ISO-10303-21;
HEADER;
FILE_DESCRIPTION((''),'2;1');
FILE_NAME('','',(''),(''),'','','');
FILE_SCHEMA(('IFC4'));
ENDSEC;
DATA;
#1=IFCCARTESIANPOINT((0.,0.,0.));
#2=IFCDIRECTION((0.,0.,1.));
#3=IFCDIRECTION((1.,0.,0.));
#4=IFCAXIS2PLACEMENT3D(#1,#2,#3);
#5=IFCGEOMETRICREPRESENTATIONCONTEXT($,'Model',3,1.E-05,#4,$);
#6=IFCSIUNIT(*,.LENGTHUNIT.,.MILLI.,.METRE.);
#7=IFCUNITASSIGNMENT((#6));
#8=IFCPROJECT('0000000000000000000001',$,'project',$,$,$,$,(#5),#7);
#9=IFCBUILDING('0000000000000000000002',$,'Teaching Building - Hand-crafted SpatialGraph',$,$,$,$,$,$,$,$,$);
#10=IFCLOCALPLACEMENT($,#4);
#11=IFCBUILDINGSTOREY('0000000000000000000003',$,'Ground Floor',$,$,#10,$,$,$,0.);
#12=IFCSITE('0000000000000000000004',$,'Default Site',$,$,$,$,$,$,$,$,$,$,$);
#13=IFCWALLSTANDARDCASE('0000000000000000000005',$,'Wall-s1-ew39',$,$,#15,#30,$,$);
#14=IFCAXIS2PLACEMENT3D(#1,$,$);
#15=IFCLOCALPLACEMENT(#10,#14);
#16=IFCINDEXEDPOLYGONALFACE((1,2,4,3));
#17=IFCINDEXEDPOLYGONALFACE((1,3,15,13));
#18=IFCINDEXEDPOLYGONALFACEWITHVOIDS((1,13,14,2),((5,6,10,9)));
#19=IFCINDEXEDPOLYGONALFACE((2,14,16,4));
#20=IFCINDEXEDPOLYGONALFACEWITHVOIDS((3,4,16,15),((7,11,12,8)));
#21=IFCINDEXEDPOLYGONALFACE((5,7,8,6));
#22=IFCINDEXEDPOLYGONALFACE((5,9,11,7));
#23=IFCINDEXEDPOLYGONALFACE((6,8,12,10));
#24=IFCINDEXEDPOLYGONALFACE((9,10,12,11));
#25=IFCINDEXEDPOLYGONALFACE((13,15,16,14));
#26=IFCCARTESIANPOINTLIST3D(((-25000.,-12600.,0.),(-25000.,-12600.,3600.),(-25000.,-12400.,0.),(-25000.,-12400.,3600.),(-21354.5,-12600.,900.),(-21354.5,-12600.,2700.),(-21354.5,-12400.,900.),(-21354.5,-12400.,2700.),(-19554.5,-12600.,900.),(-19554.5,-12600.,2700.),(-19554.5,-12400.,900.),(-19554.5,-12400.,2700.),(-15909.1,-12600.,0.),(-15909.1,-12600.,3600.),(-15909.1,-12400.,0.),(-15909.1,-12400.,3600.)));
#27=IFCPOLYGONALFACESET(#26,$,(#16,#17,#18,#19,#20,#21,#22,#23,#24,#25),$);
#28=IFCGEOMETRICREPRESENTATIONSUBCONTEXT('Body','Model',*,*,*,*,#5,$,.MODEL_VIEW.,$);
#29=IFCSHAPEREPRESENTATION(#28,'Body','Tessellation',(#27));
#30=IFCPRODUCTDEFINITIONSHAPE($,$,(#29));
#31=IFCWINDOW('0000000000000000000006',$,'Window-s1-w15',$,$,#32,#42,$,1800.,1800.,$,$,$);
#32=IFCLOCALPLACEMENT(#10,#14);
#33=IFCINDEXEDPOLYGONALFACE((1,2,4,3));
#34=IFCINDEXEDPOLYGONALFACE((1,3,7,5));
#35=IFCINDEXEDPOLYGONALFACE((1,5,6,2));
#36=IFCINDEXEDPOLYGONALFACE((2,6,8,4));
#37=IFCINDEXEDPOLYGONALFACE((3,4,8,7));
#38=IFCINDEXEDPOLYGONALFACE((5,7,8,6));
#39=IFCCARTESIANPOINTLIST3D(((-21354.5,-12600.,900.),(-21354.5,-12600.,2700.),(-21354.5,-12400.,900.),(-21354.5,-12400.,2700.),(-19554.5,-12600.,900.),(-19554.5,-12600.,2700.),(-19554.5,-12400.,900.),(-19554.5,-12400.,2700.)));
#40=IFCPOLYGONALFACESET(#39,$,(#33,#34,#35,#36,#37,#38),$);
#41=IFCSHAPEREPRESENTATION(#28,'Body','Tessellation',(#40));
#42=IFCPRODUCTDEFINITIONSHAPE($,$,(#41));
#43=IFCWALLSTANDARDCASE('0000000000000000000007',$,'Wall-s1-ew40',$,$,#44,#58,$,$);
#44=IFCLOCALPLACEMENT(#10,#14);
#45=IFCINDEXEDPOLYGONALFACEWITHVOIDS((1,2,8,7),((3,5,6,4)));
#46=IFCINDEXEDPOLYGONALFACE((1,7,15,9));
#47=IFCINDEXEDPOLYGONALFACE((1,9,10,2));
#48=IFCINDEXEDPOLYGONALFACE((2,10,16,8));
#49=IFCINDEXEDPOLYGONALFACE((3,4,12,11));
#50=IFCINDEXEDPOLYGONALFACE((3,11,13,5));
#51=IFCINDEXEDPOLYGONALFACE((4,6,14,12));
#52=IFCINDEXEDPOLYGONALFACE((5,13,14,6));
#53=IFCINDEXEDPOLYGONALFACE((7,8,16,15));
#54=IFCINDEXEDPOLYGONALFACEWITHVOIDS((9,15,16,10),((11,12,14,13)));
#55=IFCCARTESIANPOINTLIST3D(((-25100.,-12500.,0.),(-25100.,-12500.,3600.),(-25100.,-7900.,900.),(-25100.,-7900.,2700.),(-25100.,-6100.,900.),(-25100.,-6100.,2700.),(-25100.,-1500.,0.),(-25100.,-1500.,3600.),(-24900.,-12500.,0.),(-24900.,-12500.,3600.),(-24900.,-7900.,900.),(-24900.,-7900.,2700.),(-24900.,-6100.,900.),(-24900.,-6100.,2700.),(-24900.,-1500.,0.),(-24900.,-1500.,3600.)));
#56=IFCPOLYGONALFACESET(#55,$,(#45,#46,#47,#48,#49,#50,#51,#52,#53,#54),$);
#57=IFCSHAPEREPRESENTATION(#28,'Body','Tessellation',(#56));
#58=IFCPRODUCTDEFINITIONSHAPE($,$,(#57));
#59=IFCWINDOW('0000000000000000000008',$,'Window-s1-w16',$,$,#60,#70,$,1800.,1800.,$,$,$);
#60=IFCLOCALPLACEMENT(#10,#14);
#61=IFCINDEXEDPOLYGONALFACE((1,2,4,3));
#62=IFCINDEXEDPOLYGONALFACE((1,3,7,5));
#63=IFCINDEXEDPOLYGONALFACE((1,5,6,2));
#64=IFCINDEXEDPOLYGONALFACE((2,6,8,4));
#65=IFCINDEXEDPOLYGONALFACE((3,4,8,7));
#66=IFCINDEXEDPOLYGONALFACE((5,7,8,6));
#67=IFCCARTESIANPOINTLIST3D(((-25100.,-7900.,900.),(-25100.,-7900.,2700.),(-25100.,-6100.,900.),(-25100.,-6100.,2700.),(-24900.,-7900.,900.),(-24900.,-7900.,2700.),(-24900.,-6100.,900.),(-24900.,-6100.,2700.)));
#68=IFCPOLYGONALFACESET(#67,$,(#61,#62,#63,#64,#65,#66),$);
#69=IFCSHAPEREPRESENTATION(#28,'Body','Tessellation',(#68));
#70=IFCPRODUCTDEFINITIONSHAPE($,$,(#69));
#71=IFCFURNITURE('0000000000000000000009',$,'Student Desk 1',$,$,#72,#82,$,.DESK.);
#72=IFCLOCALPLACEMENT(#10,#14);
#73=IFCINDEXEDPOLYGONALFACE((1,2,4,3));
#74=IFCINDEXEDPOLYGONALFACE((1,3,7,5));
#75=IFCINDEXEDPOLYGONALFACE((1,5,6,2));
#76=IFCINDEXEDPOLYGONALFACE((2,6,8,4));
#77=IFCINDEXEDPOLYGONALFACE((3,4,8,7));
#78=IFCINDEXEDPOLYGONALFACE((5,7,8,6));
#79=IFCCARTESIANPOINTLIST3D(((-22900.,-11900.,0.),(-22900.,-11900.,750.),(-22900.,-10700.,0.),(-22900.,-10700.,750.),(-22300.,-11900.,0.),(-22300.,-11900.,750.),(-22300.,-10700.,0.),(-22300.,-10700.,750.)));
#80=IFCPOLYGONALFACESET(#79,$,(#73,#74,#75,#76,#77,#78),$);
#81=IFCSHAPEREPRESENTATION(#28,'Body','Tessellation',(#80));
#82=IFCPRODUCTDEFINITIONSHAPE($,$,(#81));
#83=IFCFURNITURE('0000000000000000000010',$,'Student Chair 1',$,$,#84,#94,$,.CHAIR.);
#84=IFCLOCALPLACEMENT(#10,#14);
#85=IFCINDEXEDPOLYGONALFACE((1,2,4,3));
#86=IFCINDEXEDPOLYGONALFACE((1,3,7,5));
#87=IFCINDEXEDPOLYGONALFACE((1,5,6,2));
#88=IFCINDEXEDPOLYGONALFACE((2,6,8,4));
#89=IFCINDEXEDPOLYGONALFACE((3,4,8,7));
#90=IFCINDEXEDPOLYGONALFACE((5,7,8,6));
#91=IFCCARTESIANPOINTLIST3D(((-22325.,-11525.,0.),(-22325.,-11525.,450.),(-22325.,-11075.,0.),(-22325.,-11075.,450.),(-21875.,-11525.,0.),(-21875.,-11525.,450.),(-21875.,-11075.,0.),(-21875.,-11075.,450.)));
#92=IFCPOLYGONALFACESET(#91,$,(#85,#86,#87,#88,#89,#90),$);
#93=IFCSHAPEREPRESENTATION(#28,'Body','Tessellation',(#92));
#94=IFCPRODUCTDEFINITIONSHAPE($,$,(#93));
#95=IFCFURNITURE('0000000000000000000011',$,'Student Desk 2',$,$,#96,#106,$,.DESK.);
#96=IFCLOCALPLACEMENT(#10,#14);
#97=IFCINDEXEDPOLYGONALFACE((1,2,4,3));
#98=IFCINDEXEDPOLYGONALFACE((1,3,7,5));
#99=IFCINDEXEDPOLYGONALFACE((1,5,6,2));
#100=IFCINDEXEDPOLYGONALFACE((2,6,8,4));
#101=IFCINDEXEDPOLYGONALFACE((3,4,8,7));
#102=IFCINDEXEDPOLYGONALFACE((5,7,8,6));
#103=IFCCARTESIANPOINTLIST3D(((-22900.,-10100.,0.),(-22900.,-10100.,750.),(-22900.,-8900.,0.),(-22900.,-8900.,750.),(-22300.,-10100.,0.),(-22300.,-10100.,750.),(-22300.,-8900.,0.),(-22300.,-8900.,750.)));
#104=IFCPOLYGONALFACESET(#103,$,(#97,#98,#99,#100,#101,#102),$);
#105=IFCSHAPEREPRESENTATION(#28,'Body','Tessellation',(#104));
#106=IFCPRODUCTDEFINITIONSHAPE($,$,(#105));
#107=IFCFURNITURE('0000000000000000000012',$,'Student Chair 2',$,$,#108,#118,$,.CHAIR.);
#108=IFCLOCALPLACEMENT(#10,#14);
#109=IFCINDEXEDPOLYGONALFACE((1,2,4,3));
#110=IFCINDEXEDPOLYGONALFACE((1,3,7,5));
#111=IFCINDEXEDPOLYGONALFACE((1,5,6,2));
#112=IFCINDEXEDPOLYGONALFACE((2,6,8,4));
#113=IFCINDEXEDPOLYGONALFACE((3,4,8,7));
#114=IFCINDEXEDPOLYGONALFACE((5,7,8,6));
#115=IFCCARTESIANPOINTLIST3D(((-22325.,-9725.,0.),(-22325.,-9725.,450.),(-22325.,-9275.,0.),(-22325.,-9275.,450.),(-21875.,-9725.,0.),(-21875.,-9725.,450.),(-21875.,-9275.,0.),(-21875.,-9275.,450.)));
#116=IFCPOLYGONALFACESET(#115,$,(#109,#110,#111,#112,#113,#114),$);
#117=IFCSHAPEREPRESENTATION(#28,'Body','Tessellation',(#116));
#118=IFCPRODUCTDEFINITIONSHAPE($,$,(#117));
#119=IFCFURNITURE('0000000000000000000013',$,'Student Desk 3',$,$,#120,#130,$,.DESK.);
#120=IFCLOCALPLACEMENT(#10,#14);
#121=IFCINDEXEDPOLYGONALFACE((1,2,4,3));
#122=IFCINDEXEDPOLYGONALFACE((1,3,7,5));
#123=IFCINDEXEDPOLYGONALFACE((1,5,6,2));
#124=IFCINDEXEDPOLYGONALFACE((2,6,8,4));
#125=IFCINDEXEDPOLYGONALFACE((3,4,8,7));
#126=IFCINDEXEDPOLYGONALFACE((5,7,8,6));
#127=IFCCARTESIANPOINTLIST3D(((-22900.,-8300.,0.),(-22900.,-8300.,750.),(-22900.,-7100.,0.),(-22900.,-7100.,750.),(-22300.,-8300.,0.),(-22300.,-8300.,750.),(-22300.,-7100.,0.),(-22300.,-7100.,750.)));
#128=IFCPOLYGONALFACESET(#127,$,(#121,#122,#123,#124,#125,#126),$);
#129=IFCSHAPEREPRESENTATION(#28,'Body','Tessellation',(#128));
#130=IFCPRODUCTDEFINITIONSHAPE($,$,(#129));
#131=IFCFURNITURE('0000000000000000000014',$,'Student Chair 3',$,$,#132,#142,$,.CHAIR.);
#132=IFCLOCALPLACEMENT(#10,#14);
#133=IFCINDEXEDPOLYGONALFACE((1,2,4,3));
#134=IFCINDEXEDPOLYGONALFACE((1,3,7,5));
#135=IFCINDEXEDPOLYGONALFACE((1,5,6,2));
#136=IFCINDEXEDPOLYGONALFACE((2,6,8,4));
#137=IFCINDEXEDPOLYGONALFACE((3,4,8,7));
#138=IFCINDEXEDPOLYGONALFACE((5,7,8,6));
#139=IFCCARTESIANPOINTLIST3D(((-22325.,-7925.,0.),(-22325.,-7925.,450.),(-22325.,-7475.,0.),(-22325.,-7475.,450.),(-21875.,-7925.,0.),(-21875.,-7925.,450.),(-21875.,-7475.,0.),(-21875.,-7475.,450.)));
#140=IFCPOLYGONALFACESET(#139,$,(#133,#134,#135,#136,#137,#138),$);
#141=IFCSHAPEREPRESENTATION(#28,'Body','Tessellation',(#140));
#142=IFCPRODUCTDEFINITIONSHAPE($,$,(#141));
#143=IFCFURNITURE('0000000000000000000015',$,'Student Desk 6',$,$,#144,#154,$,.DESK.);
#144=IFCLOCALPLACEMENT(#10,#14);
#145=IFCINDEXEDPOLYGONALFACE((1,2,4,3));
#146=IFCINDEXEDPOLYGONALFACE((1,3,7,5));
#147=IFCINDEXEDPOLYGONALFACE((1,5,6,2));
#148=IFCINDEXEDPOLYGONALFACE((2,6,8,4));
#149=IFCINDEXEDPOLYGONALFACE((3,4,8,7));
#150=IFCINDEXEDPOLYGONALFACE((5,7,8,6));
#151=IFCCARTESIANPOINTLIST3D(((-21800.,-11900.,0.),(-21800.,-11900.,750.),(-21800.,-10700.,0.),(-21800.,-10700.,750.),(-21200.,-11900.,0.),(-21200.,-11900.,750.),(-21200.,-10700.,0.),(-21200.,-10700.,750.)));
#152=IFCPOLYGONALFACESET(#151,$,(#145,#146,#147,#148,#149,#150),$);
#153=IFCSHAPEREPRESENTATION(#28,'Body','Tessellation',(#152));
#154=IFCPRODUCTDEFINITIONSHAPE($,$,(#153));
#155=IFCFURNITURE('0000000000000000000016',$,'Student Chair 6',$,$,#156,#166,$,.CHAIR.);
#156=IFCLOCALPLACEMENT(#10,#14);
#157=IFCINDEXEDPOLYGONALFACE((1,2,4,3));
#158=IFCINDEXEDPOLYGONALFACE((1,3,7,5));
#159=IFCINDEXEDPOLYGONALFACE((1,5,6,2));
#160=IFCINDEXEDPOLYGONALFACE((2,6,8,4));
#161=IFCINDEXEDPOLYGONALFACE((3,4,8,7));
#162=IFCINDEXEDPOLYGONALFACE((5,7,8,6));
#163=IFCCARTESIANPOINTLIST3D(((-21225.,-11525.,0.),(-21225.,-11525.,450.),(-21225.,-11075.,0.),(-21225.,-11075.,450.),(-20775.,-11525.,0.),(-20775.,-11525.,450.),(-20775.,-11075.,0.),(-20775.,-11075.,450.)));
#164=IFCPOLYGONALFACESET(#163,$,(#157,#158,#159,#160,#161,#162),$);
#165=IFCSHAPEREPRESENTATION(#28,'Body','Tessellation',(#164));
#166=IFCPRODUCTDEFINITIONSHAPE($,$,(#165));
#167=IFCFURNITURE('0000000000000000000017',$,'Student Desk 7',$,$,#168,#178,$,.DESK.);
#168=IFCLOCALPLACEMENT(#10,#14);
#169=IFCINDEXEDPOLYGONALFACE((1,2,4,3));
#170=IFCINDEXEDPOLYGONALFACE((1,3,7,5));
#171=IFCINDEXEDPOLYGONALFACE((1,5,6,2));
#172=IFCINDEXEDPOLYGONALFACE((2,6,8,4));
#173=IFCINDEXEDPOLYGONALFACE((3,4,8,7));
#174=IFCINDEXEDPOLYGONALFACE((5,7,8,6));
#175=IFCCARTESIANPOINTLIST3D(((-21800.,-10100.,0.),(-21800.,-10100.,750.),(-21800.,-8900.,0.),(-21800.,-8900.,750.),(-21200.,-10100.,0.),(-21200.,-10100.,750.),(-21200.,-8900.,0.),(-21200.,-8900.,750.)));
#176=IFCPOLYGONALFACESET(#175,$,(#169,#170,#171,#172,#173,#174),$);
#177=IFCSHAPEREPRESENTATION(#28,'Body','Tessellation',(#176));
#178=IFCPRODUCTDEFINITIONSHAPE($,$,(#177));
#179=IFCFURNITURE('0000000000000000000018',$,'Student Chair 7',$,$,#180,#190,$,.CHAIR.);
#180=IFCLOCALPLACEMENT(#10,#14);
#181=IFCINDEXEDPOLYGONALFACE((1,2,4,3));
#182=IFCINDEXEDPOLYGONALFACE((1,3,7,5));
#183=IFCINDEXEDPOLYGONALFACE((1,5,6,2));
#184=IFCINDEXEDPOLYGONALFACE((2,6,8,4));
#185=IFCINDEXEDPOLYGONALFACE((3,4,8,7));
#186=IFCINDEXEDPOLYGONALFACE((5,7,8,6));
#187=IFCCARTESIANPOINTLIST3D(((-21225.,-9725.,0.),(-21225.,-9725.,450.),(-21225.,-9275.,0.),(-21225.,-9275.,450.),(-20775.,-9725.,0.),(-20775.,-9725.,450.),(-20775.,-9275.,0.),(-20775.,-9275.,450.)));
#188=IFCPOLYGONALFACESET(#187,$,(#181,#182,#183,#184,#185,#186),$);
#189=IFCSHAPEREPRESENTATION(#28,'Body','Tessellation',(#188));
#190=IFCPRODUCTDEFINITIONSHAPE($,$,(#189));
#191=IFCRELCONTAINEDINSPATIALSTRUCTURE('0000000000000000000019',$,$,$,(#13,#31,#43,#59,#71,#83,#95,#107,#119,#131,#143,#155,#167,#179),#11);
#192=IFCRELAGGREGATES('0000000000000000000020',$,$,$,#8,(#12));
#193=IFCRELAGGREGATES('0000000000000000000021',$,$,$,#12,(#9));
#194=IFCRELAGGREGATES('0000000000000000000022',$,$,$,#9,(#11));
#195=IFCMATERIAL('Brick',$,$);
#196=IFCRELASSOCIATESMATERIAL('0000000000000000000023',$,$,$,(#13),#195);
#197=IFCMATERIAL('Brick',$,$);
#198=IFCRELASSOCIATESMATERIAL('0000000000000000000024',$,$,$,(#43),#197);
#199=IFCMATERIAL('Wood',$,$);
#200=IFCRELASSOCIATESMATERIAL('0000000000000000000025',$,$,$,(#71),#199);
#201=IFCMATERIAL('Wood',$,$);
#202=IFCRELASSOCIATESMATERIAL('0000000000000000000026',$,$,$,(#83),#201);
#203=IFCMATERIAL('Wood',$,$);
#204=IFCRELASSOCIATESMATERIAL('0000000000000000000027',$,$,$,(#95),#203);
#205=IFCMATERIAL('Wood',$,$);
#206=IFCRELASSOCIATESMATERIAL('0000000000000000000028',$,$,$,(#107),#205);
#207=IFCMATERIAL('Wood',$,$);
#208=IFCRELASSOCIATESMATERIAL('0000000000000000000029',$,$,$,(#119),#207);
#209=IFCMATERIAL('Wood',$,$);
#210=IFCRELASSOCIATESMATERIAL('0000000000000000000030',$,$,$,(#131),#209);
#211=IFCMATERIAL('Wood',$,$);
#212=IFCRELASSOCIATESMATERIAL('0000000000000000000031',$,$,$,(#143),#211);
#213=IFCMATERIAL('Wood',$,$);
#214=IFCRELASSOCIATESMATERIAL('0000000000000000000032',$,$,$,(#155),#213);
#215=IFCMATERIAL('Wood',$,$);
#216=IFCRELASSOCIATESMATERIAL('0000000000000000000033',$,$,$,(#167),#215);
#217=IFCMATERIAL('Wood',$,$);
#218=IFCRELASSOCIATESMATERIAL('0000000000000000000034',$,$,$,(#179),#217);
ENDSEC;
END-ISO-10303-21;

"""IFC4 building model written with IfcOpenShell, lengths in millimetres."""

from ifc_helpers import new_model, si_unit, frame, frame_2d, origin_with_axes, origin_2d, place, context, subcontext, project, spatial, rectangle, extrude, material, element, fill, save


model = new_model("IFC4")

# Units and contexts
model_context = context("Model", 3, precision=1e-05, world=origin_with_axes())
body_context = subcontext(model_context, "Body", "Model", "MODEL_VIEW")
ifc_project = project(units=[si_unit("LENGTHUNIT", "METRE", prefix="MILLI")], contexts=[model_context])

# Site, building, storey
site = spatial("IfcSite", under=ifc_project, Name="Default Site")
building = spatial("IfcBuilding", under=site, Name="Teaching Building - Hand-crafted SpatialGraph")
storey_placement = place(None, origin_with_axes())
storey = spatial("IfcBuildingStorey", under=building, at=storey_placement, Name="Ground Floor", Elevation=0.0)

# Walls, openings, windows
ifc_material_1 = material(Name="Brick")
wall_1_placement = place(storey_placement, frame((-25000.0, -12500.0, 0.0), z_axis=(0.0, 0.0, 1.0), x_axis=(1.0, 0.0, 0.0)))
wall_1 = element("IfcWallStandardCase", 1, at=wall_1_placement, inside=storey, material=ifc_material_1, Name="Wall-s1-ew39", context=body_context, shape_type="SweptSolid", body=[
    extrude(rectangle(XDim=9090.9, YDim=200.0, at=frame_2d((4545.5, 0.0))), origin_with_axes(), (0.0, 0.0, 1.0), 3600.0),
])
opening_1_placement = place(wall_1_placement, frame((3645.5, 0.0, 900.0), z_axis=(0.0, 0.0, 1.0), x_axis=(1.0, 0.0, 0.0)))
opening_1 = element("IfcOpeningElement", 2, at=opening_1_placement, cuts=wall_1, context=body_context, shape_type="SweptSolid", body=[
    extrude(rectangle(XDim=1800.0, YDim=400.0, at=frame_2d((900.0, 0.0))), origin_with_axes(), (0.0, 0.0, 1.0), 1800.0),
])
window_1_placement = place(storey_placement, frame((-21354.5, -12500.0, 900.0), z_axis=(0.0, 0.0, 1.0), x_axis=(1.0, 0.0, 0.0)))
window_1 = element("IfcWindow", 3, at=window_1_placement, inside=storey, Name="Window-s1-w15", OverallHeight=1800.0, OverallWidth=1800.0, context=body_context, shape_type="SweptSolid", body=[
    extrude(rectangle(XDim=1800.0, YDim=200.0, at=frame_2d((900.0, 0.0))), origin_with_axes(), (0.0, 0.0, 1.0), 1800.0),
])
fill(opening_1, window_1)
ifc_material_2 = material(Name="Brick")
wall_2_placement = place(storey_placement, frame((-25000.0, -12500.0, 0.0), z_axis=(0.0, 0.0, 1.0), x_axis=(0.0, 1.0, 0.0)))
wall_2 = element("IfcWallStandardCase", 4, at=wall_2_placement, inside=storey, material=ifc_material_2, Name="Wall-s1-ew40", context=body_context, shape_type="SweptSolid", body=[
    extrude(rectangle(XDim=11000.0, YDim=200.0, at=frame_2d((5500.0, 0.0))), origin_with_axes(), (0.0, 0.0, 1.0), 3600.0),
])
opening_2_placement = place(wall_2_placement, frame((4600.0, 0.0, 900.0), z_axis=(0.0, 0.0, 1.0), x_axis=(1.0, 0.0, 0.0)))
opening_2 = element("IfcOpeningElement", 5, at=opening_2_placement, cuts=wall_2, context=body_context, shape_type="SweptSolid", body=[
    extrude(rectangle(XDim=1800.0, YDim=400.0, at=frame_2d((900.0, 0.0))), origin_with_axes(), (0.0, 0.0, 1.0), 1800.0),
])
window_2_placement = place(storey_placement, frame((-25000.0, -7900.0, 900.0), z_axis=(0.0, 0.0, 1.0), x_axis=(0.0, 1.0, 0.0)))
window_2 = element("IfcWindow", 6, at=window_2_placement, inside=storey, Name="Window-s1-w16", OverallHeight=1800.0, OverallWidth=1800.0, context=body_context, shape_type="SweptSolid", body=[
    extrude(rectangle(XDim=1800.0, YDim=200.0, at=frame_2d((900.0, 0.0))), origin_with_axes(), (0.0, 0.0, 1.0), 1800.0),
])
fill(opening_2, window_2)

# Furniture
ifc_material_3 = material(Name="Wood")
furniture_1_placement = place(storey_placement, frame((-22600.0, -11300.0, 0.0), z_axis=(0.0, 0.0, 1.0), x_axis=(0.0, 1.0, 0.0)))
element("IfcFurniture", 7, at=furniture_1_placement, inside=storey, material=ifc_material_3, Name="Student Desk 1", PredefinedType="DESK", context=body_context, shape_type="SweptSolid", body=[
    extrude(rectangle(XDim=1200.0, YDim=600.0, at=origin_2d()), origin_with_axes(), (0.0, 0.0, 1.0), 750.0),
])
ifc_material_4 = material(Name="Wood")
furniture_2_placement = place(storey_placement, frame((-22100.0, -11300.0, 0.0), z_axis=(0.0, 0.0, 1.0), x_axis=(1.0, 0.0, 0.0)))
element("IfcFurniture", 8, at=furniture_2_placement, inside=storey, material=ifc_material_4, Name="Student Chair 1", PredefinedType="CHAIR", context=body_context, shape_type="SweptSolid", body=[
    extrude(rectangle(XDim=450.0, YDim=450.0, at=origin_2d()), origin_with_axes(), (0.0, 0.0, 1.0), 450.0),
])
ifc_material_5 = material(Name="Wood")
furniture_3_placement = place(storey_placement, frame((-22600.0, -9500.0, 0.0), z_axis=(0.0, 0.0, 1.0), x_axis=(0.0, 1.0, 0.0)))
element("IfcFurniture", 9, at=furniture_3_placement, inside=storey, material=ifc_material_5, Name="Student Desk 2", PredefinedType="DESK", context=body_context, shape_type="SweptSolid", body=[
    extrude(rectangle(XDim=1200.0, YDim=600.0, at=origin_2d()), origin_with_axes(), (0.0, 0.0, 1.0), 750.0),
])
ifc_material_6 = material(Name="Wood")
furniture_4_placement = place(storey_placement, frame((-22100.0, -9500.0, 0.0), z_axis=(0.0, 0.0, 1.0), x_axis=(1.0, 0.0, 0.0)))
element("IfcFurniture", 10, at=furniture_4_placement, inside=storey, material=ifc_material_6, Name="Student Chair 2", PredefinedType="CHAIR", context=body_context, shape_type="SweptSolid", body=[
    extrude(rectangle(XDim=450.0, YDim=450.0, at=origin_2d()), origin_with_axes(), (0.0, 0.0, 1.0), 450.0),
])
ifc_material_7 = material(Name="Wood")
furniture_5_placement = place(storey_placement, frame((-22600.0, -7700.0, 0.0), z_axis=(0.0, 0.0, 1.0), x_axis=(0.0, 1.0, 0.0)))
element("IfcFurniture", 11, at=furniture_5_placement, inside=storey, material=ifc_material_7, Name="Student Desk 3", PredefinedType="DESK", context=body_context, shape_type="SweptSolid", body=[
    extrude(rectangle(XDim=1200.0, YDim=600.0, at=origin_2d()), origin_with_axes(), (0.0, 0.0, 1.0), 750.0),
])
ifc_material_8 = material(Name="Wood")
furniture_6_placement = place(storey_placement, frame((-22100.0, -7700.0, 0.0), z_axis=(0.0, 0.0, 1.0), x_axis=(1.0, 0.0, 0.0)))
element("IfcFurniture", 12, at=furniture_6_placement, inside=storey, material=ifc_material_8, Name="Student Chair 3", PredefinedType="CHAIR", context=body_context, shape_type="SweptSolid", body=[
    extrude(rectangle(XDim=450.0, YDim=450.0, at=origin_2d()), origin_with_axes(), (0.0, 0.0, 1.0), 450.0),
])
ifc_material_9 = material(Name="Wood")
furniture_7_placement = place(storey_placement, frame((-21500.0, -11300.0, 0.0), z_axis=(0.0, 0.0, 1.0), x_axis=(0.0, 1.0, 0.0)))
element("IfcFurniture", 13, at=furniture_7_placement, inside=storey, material=ifc_material_9, Name="Student Desk 6", PredefinedType="DESK", context=body_context, shape_type="SweptSolid", body=[
    extrude(rectangle(XDim=1200.0, YDim=600.0, at=origin_2d()), origin_with_axes(), (0.0, 0.0, 1.0), 750.0),
])
ifc_material_10 = material(Name="Wood")
furniture_8_placement = place(storey_placement, frame((-21000.0, -11300.0, 0.0), z_axis=(0.0, 0.0, 1.0), x_axis=(1.0, 0.0, 0.0)))
element("IfcFurniture", 14, at=furniture_8_placement, inside=storey, material=ifc_material_10, Name="Student Chair 6", PredefinedType="CHAIR", context=body_context, shape_type="SweptSolid", body=[
    extrude(rectangle(XDim=450.0, YDim=450.0, at=origin_2d()), origin_with_axes(), (0.0, 0.0, 1.0), 450.0),
])
ifc_material_11 = material(Name="Wood")
furniture_9_placement = place(storey_placement, frame((-21500.0, -9500.0, 0.0), z_axis=(0.0, 0.0, 1.0), x_axis=(0.0, 1.0, 0.0)))
element("IfcFurniture", 15, at=furniture_9_placement, inside=storey, material=ifc_material_11, Name="Student Desk 7", PredefinedType="DESK", context=body_context, shape_type="SweptSolid", body=[
    extrude(rectangle(XDim=1200.0, YDim=600.0, at=origin_2d()), origin_with_axes(), (0.0, 0.0, 1.0), 750.0),
])
ifc_material_12 = material(Name="Wood")
furniture_10_placement = place(storey_placement, frame((-21000.0, -9500.0, 0.0), z_axis=(0.0, 0.0, 1.0), x_axis=(1.0, 0.0, 0.0)))
element("IfcFurniture", 16, at=furniture_10_placement, inside=storey, material=ifc_material_12, Name="Student Chair 7", PredefinedType="CHAIR", context=body_context, shape_type="SweptSolid", body=[
    extrude(rectangle(XDim=450.0, YDim=450.0, at=origin_2d()), origin_with_axes(), (0.0, 0.0, 1.0), 450.0),
])

save(model, "model.ifc")
